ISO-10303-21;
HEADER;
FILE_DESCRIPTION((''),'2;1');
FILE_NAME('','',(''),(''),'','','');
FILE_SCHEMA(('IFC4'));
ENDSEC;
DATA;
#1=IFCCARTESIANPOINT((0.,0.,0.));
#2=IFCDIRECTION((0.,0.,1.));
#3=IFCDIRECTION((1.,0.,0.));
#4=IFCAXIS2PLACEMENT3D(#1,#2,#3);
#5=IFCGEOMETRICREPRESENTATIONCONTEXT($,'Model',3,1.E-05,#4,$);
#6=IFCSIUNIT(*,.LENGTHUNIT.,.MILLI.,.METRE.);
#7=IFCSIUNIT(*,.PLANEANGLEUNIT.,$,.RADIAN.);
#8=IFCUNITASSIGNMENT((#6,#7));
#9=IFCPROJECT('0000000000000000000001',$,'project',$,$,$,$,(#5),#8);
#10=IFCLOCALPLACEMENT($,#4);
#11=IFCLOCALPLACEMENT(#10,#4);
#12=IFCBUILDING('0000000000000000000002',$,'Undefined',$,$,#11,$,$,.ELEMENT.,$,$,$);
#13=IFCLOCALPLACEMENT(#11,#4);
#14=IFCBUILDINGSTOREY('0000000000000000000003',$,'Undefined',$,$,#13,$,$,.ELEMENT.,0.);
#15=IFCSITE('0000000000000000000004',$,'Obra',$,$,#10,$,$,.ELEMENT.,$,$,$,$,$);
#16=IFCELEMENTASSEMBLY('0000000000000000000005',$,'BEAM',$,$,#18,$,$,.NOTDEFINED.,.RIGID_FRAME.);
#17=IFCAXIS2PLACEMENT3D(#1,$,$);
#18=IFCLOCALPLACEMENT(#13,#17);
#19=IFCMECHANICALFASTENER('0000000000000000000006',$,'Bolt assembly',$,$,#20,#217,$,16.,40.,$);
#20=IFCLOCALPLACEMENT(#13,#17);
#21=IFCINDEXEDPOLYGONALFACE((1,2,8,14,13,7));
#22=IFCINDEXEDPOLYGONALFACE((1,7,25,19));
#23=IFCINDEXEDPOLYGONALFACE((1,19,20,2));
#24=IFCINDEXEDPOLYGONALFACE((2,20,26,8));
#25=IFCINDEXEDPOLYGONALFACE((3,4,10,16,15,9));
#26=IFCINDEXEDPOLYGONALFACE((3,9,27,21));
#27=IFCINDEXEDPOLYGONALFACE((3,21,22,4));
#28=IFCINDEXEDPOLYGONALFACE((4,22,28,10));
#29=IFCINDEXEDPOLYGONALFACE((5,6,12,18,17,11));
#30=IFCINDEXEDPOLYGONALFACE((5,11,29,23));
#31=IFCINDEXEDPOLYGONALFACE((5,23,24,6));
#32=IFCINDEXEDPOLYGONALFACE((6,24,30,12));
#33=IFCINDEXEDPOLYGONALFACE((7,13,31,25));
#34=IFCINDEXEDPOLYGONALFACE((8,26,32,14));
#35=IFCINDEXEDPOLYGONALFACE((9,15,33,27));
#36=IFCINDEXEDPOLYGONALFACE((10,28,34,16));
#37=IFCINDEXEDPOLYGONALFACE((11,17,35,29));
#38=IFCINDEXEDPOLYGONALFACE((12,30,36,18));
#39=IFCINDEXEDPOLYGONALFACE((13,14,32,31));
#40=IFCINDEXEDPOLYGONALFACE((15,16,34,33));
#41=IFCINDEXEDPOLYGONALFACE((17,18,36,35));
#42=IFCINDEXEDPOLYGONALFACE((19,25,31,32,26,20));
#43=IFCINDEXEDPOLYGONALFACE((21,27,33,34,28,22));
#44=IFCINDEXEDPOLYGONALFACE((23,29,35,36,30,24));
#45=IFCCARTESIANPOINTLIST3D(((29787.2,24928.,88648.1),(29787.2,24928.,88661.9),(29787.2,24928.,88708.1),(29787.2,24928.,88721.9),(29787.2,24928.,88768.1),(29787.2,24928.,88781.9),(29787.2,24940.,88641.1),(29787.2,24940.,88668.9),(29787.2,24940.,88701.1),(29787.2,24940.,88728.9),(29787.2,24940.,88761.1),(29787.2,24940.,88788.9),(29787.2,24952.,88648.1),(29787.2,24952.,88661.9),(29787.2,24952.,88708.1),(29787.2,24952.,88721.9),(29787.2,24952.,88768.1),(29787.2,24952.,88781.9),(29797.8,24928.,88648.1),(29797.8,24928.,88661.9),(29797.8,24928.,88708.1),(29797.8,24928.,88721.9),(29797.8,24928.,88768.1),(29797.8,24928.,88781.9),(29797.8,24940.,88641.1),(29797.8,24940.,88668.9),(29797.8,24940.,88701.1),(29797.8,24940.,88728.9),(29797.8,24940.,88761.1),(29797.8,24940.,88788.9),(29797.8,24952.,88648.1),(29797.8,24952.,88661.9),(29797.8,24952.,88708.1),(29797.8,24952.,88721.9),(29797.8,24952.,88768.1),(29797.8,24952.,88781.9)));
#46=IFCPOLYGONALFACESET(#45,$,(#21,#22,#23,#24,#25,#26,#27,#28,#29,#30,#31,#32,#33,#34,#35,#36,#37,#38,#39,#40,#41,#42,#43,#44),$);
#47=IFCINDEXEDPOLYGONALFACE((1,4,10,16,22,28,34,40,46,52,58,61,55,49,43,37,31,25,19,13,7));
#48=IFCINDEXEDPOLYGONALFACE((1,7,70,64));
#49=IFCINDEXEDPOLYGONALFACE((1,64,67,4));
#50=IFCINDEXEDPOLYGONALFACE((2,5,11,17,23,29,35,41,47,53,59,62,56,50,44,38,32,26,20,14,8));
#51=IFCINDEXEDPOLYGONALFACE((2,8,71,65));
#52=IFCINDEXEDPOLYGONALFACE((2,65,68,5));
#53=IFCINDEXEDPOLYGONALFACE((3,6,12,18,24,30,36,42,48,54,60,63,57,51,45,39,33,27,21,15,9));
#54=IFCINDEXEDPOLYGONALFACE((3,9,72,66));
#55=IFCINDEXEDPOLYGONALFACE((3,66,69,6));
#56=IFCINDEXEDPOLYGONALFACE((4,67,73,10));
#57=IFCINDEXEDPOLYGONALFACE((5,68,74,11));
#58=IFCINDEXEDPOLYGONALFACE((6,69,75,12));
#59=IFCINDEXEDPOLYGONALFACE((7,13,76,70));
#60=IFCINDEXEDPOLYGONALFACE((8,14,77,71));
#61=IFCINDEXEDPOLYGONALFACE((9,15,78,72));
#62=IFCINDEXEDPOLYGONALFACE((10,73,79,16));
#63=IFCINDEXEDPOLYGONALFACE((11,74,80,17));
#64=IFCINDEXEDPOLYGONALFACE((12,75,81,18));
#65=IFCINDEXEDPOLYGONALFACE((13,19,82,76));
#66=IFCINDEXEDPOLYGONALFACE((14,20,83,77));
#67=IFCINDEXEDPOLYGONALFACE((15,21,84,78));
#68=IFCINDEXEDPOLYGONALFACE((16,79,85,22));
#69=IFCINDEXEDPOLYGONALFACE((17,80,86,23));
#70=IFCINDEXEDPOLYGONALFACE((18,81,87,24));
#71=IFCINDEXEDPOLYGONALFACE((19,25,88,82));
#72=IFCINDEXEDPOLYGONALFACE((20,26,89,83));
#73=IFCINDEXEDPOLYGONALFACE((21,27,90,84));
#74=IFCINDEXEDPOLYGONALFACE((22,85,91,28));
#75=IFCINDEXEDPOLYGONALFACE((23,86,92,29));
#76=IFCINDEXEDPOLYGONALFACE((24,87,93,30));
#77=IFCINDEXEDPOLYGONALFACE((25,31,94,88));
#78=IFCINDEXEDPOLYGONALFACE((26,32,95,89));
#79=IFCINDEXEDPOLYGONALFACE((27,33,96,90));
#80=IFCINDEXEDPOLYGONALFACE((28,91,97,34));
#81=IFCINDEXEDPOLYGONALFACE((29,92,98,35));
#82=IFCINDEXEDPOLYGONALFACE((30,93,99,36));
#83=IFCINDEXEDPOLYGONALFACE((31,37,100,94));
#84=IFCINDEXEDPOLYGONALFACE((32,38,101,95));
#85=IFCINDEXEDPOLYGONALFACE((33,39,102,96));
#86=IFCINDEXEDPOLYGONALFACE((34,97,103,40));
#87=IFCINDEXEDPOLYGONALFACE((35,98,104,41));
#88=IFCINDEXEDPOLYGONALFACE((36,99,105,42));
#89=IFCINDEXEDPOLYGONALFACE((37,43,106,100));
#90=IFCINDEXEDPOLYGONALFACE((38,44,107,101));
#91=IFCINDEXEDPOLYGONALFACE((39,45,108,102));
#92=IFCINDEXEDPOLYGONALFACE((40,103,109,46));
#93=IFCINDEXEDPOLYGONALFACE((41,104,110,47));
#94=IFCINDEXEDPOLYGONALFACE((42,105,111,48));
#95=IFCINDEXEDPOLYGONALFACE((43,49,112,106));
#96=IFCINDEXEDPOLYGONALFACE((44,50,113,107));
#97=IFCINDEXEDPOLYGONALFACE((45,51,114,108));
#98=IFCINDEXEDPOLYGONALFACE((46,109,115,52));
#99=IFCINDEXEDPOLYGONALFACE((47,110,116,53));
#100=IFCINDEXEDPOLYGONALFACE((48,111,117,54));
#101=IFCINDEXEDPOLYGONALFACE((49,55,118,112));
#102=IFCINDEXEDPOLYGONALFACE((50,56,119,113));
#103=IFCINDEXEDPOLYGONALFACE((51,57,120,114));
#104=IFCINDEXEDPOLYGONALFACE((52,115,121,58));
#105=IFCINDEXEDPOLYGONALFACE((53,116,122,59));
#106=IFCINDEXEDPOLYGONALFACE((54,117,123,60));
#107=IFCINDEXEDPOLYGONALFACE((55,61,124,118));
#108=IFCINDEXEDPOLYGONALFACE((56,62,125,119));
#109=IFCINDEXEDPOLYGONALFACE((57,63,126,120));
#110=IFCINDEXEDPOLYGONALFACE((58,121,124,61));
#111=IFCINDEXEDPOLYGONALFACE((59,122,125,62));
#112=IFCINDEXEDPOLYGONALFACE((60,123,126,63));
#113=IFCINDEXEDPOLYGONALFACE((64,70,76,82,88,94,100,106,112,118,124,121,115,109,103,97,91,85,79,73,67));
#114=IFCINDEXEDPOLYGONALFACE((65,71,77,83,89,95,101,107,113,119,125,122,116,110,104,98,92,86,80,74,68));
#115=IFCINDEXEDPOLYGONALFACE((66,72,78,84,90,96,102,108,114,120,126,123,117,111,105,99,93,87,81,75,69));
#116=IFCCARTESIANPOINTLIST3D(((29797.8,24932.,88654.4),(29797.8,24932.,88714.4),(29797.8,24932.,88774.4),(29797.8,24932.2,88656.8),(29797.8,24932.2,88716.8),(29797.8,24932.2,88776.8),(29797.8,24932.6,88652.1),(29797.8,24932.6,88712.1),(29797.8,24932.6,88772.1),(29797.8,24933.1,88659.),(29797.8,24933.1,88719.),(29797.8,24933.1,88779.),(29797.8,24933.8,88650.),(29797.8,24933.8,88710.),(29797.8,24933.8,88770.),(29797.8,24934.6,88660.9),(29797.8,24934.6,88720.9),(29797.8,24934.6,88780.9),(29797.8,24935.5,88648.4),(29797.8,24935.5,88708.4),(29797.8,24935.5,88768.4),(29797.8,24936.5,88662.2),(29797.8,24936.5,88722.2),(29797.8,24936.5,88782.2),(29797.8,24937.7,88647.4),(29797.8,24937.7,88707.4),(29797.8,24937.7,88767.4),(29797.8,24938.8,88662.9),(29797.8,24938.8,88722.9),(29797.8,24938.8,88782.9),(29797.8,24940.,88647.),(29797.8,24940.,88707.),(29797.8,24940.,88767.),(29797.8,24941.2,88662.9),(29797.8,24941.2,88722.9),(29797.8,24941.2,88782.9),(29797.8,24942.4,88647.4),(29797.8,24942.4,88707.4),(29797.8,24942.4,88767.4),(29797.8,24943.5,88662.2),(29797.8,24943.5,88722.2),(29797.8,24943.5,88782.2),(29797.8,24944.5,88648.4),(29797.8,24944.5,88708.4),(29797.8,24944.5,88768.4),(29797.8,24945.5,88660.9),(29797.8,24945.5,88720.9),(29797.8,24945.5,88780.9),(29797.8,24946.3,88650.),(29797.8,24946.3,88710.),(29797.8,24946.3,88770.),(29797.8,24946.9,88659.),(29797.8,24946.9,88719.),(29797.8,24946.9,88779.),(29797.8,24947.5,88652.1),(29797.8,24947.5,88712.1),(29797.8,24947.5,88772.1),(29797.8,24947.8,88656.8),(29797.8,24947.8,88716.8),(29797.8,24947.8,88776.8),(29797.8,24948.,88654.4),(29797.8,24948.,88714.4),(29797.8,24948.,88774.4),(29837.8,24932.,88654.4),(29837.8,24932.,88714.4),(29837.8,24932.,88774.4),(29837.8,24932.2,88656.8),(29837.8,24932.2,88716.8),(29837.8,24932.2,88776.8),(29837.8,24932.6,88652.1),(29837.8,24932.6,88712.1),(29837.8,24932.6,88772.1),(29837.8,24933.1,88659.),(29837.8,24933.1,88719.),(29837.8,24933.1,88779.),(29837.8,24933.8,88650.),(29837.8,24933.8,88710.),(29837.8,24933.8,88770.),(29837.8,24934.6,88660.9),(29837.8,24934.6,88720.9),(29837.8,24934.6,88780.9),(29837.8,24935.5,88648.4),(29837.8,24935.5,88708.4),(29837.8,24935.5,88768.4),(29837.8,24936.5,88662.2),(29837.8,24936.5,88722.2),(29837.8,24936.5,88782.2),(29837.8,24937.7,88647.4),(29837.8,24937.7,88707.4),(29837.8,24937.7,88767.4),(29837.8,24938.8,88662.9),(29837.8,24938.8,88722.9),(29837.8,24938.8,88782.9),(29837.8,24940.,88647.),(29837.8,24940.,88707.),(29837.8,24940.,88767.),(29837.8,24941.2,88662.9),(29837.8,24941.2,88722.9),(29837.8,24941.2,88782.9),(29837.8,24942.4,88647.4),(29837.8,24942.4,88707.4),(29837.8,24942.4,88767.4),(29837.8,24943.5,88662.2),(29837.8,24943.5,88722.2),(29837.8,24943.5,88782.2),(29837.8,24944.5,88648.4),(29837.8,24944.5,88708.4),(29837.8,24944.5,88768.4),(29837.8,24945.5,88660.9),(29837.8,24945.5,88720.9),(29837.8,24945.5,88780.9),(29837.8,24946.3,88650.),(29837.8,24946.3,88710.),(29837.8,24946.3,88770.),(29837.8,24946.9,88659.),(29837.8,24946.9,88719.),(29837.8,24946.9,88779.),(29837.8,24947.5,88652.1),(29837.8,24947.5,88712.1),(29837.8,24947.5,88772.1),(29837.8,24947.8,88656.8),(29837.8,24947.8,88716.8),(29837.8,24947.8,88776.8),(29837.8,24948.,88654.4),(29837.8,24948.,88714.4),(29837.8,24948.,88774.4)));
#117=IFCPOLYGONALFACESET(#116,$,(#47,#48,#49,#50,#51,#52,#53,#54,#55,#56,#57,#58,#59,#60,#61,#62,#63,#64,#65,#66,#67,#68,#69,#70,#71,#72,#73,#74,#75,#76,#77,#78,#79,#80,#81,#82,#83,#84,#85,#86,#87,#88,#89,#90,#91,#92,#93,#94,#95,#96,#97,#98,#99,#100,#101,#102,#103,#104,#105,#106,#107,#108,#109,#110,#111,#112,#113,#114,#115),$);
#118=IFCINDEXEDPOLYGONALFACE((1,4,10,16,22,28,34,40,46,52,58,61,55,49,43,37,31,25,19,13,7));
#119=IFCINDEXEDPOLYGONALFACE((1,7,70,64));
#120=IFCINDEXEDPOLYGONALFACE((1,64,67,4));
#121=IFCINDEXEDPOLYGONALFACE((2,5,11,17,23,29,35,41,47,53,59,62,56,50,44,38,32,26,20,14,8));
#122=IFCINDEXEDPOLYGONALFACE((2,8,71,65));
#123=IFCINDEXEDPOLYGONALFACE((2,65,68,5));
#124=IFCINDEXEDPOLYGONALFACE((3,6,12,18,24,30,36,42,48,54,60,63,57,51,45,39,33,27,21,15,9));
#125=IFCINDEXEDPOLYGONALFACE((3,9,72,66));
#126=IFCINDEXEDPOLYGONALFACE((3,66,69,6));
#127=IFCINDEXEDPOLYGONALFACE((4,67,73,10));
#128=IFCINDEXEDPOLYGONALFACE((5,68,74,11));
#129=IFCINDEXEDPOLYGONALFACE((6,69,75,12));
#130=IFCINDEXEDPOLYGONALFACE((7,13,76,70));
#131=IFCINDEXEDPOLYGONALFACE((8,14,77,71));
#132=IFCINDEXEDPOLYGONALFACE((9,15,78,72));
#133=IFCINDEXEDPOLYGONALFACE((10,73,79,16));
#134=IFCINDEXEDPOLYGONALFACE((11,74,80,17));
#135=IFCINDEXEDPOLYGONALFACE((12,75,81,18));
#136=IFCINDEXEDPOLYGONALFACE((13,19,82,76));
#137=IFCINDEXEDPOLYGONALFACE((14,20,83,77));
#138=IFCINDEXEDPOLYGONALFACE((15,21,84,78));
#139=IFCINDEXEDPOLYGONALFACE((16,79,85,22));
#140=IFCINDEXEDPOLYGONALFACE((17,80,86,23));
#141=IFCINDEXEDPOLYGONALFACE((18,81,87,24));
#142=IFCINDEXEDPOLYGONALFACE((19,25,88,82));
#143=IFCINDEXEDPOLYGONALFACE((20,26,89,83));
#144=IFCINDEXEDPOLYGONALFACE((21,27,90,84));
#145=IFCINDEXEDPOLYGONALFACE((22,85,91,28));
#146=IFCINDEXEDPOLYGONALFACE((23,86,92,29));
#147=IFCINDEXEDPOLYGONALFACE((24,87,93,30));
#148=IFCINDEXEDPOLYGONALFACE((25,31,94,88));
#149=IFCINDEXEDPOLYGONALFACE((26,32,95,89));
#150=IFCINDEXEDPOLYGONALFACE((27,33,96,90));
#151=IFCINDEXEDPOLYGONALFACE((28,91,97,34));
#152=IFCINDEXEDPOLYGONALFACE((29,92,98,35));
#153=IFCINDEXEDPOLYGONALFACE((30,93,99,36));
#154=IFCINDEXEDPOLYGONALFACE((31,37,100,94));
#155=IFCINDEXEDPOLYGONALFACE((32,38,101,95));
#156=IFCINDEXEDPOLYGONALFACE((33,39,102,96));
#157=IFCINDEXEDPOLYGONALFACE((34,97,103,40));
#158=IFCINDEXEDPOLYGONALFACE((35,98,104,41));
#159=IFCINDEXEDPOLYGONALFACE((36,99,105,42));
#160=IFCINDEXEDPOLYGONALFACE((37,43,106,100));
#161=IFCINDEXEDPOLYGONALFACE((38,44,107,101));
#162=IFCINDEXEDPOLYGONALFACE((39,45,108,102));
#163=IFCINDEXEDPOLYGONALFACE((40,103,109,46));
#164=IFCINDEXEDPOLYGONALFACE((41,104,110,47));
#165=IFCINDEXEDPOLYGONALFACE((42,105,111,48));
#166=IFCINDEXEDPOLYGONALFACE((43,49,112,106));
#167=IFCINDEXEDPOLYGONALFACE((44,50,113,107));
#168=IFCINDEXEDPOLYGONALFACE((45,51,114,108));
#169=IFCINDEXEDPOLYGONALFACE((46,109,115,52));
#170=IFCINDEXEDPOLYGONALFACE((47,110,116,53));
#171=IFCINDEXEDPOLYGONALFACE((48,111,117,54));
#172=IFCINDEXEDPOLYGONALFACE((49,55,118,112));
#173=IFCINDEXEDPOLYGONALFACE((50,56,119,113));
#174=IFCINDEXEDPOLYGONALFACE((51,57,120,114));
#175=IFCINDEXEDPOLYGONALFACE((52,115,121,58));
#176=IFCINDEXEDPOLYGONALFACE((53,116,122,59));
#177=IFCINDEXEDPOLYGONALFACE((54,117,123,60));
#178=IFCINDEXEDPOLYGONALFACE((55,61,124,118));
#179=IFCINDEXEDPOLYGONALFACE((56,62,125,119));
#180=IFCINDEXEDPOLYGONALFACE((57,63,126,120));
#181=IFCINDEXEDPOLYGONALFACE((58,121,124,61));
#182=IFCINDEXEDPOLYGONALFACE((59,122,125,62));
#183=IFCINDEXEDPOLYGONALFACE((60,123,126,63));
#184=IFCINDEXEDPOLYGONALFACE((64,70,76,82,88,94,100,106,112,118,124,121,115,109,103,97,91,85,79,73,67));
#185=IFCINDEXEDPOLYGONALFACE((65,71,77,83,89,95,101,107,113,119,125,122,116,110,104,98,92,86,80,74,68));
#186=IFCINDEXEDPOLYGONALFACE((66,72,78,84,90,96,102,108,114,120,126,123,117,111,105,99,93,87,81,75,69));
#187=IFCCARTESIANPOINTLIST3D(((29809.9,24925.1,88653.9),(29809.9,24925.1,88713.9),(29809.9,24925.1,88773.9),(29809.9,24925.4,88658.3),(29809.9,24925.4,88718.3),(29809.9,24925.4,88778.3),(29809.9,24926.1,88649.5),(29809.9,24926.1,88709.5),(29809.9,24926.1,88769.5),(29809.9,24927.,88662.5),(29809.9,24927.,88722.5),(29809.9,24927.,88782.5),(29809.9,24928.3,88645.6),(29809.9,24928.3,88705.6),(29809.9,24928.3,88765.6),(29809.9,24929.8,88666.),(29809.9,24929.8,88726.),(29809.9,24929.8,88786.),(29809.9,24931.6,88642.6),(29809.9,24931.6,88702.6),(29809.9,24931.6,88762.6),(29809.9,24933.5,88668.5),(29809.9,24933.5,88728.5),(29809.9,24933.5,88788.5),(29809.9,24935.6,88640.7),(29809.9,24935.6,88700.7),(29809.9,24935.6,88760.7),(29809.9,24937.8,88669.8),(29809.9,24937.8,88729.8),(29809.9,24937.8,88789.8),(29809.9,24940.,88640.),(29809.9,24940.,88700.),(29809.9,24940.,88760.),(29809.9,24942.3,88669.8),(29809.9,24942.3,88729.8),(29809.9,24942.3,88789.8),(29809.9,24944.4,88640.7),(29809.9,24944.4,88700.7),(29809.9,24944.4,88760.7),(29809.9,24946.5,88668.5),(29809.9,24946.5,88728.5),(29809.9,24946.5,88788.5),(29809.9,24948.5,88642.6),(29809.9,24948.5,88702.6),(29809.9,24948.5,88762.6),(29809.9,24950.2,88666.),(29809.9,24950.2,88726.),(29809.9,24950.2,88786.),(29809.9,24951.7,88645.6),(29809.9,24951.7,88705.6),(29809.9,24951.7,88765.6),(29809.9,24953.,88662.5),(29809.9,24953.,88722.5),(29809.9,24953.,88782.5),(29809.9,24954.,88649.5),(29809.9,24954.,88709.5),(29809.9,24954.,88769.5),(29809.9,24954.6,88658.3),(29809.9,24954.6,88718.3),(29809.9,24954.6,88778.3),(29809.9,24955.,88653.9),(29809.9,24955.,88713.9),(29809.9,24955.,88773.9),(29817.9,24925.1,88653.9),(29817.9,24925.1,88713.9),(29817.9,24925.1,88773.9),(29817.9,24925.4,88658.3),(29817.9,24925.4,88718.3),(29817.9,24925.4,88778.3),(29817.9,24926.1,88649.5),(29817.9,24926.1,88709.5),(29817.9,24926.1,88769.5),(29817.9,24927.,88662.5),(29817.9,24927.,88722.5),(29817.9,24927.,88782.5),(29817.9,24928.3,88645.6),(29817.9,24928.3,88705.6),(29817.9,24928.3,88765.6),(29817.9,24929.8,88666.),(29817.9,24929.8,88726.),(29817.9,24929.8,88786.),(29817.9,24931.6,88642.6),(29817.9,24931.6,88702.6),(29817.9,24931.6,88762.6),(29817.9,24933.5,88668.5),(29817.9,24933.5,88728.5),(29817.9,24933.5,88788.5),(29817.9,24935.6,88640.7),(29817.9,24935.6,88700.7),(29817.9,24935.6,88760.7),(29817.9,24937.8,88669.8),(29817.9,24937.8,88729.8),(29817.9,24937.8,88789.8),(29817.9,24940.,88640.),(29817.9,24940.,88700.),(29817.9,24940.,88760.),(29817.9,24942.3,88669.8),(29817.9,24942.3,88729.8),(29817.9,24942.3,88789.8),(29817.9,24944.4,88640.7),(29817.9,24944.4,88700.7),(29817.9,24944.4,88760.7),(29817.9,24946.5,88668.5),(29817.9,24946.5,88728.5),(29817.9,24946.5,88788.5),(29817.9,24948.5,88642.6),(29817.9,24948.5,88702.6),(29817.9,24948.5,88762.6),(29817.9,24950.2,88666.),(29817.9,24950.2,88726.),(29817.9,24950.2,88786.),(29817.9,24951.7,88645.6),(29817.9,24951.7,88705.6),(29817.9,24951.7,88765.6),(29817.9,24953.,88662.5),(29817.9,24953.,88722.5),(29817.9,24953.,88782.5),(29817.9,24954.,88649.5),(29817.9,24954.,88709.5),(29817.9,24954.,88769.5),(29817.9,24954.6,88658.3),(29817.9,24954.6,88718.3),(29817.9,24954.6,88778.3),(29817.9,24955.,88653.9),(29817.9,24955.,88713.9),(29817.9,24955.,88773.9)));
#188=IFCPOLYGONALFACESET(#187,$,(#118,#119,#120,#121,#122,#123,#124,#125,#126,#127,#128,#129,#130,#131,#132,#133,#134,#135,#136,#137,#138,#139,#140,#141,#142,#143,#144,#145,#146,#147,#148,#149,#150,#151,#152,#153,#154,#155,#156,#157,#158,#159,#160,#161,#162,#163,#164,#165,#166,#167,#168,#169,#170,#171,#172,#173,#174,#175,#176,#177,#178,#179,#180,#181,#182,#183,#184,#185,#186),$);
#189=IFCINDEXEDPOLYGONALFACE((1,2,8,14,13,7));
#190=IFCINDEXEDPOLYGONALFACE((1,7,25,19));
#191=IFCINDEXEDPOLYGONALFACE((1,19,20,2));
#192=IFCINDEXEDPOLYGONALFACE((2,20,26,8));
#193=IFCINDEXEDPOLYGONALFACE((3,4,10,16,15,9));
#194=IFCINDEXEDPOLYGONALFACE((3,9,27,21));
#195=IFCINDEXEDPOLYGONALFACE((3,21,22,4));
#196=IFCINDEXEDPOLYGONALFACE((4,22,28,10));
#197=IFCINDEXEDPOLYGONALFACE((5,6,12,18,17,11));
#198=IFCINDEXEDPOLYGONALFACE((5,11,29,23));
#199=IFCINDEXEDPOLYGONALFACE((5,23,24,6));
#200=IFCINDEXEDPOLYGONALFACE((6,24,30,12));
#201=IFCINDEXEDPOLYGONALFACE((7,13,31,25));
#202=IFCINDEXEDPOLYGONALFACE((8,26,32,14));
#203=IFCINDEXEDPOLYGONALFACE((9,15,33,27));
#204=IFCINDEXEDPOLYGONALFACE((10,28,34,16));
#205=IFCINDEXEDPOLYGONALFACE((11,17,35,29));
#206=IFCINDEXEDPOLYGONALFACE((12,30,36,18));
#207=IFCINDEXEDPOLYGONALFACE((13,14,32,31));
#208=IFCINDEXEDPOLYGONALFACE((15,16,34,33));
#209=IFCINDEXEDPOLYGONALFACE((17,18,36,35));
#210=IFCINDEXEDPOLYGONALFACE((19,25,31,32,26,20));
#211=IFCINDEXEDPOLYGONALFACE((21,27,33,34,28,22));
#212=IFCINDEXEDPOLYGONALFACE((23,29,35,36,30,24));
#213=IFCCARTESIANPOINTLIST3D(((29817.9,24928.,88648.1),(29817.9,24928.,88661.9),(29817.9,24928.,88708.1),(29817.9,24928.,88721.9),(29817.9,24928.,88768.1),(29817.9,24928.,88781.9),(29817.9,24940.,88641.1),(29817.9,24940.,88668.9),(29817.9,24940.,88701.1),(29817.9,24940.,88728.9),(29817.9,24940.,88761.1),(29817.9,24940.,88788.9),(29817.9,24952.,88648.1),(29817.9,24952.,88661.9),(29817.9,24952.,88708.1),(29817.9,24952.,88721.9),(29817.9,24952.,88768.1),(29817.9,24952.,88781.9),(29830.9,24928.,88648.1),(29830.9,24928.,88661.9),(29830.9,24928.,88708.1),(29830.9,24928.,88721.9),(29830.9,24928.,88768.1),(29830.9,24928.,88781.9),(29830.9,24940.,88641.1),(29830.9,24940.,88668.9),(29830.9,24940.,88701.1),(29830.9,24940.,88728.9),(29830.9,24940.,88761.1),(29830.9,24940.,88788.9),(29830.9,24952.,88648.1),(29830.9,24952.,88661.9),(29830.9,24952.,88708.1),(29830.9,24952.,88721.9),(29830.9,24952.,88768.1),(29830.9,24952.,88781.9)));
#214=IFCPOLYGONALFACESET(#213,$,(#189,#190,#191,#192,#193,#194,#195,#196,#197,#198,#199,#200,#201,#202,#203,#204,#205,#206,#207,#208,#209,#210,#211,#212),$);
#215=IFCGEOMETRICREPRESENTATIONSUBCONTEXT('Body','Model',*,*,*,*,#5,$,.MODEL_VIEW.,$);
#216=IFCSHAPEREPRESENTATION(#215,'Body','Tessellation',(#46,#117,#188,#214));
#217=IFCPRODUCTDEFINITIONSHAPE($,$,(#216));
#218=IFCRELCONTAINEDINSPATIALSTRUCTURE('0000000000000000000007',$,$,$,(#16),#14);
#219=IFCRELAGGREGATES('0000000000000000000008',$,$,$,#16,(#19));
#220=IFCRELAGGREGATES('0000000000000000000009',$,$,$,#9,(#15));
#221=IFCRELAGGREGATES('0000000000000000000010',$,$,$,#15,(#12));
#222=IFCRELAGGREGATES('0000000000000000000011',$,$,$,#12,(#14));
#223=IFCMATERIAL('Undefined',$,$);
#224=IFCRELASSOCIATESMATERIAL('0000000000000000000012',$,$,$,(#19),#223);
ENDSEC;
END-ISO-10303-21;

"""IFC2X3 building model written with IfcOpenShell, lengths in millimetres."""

from ifc_helpers import new_model, si_unit, frame, origin_with_axes, origin_2d_with_axis, place, context, subcontext, project, spatial, polyline, circle, outline, extrude, source, transform, mapped, material, element, aggregate, save


model = new_model("IFC2X3")

# Units and contexts
model_context = context("Model", 3, precision=1e-05, world=origin_with_axes())
body_context = subcontext(model_context, "Body", "Model", "MODEL_VIEW")
ifc_project = project(units=[si_unit("LENGTHUNIT", "METRE", prefix="MILLI"), si_unit("PLANEANGLEUNIT", "RADIAN")], contexts=[model_context])

# Site, building, storey
site_placement = place(None, origin_with_axes())
site = spatial("IfcSite", under=ifc_project, at=site_placement, Name="Obra", CompositionType="ELEMENT")
building_placement = place(site_placement, origin_with_axes())
building = spatial("IfcBuilding", under=site, at=building_placement, Name="Undefined", CompositionType="ELEMENT")
storey_placement = place(building_placement, origin_with_axes())
storey = spatial("IfcBuildingStorey", under=building, at=storey_placement, Name="Undefined", CompositionType="ELEMENT", Elevation=0.0)

# Shared definitions
ifc_material_1 = material(Name="Undefined")

# Element assembly
assembly_1_placement = place(storey_placement, origin_with_axes())
assembly_1 = element("IfcElementAssembly", 1, at=assembly_1_placement, inside=storey, Name="BEAM", AssemblyPlace="NOTDEFINED", PredefinedType="RIGID_FRAME")

# Mechanical fastener
shared_shape_1 = source(origin_with_axes(), body_context, "Body", "SweptSolid", [
    extrude(outline(polyline([(13.9, 0.0), (6.9, 12.0), (-6.9, 12.0), (-13.9, 0.0), (-6.9, -12.0), (6.9, -12.0), (13.9, 0.0)])), frame((0.0, -19.7, 0.0), z_axis=(0.0, 1.0, 0.0), x_axis=(1.0, 0.0, 0.0)), (0.0, 0.0, 1.0), 10.6),
    extrude(circle(Radius=8.0, at=origin_2d_with_axis()), frame((0.0, -9.1, 0.0), z_axis=(0.0, 1.0, 0.0), x_axis=(1.0, 0.0, 0.0)), (0.0, 0.0, 1.0), 40.0),
    extrude(circle(Radius=15.0, at=origin_2d_with_axis()), frame((0.0, 3.0, 0.0), z_axis=(0.0, 1.0, 0.0), x_axis=(1.0, 0.0, 0.0)), (0.0, 0.0, 1.0), 8.0),
    extrude(outline(polyline([(13.9, 0.0), (6.9, 12.0), (-6.9, 12.0), (-13.9, 0.0), (-6.9, -12.0), (6.9, -12.0), (13.9, 0.0)])), frame((0.0, 11.0, 0.0), z_axis=(0.0, 1.0, 0.0), x_axis=(1.0, 0.0, 0.0)), (0.0, 0.0, 1.0), 13.0),
])
mechanical_fastener_1_placement = place(assembly_1_placement, frame((29806.9, 24990.0, 88835.0), z_axis=(0.000002, -1.0, 0.0), x_axis=(0.0, 0.0, -1.0)))
mechanical_fastener_1 = element("IfcMechanicalFastener", 2, at=mechanical_fastener_1_placement, material=ifc_material_1, Name="Bolt assembly", NominalDiameter=16.0, NominalLength=40.0, context=body_context, shape_type="MappedRepresentation", body=[
    mapped(shared_shape_1, transform((60.0, 0.0, 50.0))),
    mapped(shared_shape_1, transform((120.0, 0.0, 50.0))),
    mapped(shared_shape_1, transform((180.0, 0.0, 50.0))),
])
aggregate(assembly_1, [mechanical_fastener_1])

save(model, "model.ifc")
